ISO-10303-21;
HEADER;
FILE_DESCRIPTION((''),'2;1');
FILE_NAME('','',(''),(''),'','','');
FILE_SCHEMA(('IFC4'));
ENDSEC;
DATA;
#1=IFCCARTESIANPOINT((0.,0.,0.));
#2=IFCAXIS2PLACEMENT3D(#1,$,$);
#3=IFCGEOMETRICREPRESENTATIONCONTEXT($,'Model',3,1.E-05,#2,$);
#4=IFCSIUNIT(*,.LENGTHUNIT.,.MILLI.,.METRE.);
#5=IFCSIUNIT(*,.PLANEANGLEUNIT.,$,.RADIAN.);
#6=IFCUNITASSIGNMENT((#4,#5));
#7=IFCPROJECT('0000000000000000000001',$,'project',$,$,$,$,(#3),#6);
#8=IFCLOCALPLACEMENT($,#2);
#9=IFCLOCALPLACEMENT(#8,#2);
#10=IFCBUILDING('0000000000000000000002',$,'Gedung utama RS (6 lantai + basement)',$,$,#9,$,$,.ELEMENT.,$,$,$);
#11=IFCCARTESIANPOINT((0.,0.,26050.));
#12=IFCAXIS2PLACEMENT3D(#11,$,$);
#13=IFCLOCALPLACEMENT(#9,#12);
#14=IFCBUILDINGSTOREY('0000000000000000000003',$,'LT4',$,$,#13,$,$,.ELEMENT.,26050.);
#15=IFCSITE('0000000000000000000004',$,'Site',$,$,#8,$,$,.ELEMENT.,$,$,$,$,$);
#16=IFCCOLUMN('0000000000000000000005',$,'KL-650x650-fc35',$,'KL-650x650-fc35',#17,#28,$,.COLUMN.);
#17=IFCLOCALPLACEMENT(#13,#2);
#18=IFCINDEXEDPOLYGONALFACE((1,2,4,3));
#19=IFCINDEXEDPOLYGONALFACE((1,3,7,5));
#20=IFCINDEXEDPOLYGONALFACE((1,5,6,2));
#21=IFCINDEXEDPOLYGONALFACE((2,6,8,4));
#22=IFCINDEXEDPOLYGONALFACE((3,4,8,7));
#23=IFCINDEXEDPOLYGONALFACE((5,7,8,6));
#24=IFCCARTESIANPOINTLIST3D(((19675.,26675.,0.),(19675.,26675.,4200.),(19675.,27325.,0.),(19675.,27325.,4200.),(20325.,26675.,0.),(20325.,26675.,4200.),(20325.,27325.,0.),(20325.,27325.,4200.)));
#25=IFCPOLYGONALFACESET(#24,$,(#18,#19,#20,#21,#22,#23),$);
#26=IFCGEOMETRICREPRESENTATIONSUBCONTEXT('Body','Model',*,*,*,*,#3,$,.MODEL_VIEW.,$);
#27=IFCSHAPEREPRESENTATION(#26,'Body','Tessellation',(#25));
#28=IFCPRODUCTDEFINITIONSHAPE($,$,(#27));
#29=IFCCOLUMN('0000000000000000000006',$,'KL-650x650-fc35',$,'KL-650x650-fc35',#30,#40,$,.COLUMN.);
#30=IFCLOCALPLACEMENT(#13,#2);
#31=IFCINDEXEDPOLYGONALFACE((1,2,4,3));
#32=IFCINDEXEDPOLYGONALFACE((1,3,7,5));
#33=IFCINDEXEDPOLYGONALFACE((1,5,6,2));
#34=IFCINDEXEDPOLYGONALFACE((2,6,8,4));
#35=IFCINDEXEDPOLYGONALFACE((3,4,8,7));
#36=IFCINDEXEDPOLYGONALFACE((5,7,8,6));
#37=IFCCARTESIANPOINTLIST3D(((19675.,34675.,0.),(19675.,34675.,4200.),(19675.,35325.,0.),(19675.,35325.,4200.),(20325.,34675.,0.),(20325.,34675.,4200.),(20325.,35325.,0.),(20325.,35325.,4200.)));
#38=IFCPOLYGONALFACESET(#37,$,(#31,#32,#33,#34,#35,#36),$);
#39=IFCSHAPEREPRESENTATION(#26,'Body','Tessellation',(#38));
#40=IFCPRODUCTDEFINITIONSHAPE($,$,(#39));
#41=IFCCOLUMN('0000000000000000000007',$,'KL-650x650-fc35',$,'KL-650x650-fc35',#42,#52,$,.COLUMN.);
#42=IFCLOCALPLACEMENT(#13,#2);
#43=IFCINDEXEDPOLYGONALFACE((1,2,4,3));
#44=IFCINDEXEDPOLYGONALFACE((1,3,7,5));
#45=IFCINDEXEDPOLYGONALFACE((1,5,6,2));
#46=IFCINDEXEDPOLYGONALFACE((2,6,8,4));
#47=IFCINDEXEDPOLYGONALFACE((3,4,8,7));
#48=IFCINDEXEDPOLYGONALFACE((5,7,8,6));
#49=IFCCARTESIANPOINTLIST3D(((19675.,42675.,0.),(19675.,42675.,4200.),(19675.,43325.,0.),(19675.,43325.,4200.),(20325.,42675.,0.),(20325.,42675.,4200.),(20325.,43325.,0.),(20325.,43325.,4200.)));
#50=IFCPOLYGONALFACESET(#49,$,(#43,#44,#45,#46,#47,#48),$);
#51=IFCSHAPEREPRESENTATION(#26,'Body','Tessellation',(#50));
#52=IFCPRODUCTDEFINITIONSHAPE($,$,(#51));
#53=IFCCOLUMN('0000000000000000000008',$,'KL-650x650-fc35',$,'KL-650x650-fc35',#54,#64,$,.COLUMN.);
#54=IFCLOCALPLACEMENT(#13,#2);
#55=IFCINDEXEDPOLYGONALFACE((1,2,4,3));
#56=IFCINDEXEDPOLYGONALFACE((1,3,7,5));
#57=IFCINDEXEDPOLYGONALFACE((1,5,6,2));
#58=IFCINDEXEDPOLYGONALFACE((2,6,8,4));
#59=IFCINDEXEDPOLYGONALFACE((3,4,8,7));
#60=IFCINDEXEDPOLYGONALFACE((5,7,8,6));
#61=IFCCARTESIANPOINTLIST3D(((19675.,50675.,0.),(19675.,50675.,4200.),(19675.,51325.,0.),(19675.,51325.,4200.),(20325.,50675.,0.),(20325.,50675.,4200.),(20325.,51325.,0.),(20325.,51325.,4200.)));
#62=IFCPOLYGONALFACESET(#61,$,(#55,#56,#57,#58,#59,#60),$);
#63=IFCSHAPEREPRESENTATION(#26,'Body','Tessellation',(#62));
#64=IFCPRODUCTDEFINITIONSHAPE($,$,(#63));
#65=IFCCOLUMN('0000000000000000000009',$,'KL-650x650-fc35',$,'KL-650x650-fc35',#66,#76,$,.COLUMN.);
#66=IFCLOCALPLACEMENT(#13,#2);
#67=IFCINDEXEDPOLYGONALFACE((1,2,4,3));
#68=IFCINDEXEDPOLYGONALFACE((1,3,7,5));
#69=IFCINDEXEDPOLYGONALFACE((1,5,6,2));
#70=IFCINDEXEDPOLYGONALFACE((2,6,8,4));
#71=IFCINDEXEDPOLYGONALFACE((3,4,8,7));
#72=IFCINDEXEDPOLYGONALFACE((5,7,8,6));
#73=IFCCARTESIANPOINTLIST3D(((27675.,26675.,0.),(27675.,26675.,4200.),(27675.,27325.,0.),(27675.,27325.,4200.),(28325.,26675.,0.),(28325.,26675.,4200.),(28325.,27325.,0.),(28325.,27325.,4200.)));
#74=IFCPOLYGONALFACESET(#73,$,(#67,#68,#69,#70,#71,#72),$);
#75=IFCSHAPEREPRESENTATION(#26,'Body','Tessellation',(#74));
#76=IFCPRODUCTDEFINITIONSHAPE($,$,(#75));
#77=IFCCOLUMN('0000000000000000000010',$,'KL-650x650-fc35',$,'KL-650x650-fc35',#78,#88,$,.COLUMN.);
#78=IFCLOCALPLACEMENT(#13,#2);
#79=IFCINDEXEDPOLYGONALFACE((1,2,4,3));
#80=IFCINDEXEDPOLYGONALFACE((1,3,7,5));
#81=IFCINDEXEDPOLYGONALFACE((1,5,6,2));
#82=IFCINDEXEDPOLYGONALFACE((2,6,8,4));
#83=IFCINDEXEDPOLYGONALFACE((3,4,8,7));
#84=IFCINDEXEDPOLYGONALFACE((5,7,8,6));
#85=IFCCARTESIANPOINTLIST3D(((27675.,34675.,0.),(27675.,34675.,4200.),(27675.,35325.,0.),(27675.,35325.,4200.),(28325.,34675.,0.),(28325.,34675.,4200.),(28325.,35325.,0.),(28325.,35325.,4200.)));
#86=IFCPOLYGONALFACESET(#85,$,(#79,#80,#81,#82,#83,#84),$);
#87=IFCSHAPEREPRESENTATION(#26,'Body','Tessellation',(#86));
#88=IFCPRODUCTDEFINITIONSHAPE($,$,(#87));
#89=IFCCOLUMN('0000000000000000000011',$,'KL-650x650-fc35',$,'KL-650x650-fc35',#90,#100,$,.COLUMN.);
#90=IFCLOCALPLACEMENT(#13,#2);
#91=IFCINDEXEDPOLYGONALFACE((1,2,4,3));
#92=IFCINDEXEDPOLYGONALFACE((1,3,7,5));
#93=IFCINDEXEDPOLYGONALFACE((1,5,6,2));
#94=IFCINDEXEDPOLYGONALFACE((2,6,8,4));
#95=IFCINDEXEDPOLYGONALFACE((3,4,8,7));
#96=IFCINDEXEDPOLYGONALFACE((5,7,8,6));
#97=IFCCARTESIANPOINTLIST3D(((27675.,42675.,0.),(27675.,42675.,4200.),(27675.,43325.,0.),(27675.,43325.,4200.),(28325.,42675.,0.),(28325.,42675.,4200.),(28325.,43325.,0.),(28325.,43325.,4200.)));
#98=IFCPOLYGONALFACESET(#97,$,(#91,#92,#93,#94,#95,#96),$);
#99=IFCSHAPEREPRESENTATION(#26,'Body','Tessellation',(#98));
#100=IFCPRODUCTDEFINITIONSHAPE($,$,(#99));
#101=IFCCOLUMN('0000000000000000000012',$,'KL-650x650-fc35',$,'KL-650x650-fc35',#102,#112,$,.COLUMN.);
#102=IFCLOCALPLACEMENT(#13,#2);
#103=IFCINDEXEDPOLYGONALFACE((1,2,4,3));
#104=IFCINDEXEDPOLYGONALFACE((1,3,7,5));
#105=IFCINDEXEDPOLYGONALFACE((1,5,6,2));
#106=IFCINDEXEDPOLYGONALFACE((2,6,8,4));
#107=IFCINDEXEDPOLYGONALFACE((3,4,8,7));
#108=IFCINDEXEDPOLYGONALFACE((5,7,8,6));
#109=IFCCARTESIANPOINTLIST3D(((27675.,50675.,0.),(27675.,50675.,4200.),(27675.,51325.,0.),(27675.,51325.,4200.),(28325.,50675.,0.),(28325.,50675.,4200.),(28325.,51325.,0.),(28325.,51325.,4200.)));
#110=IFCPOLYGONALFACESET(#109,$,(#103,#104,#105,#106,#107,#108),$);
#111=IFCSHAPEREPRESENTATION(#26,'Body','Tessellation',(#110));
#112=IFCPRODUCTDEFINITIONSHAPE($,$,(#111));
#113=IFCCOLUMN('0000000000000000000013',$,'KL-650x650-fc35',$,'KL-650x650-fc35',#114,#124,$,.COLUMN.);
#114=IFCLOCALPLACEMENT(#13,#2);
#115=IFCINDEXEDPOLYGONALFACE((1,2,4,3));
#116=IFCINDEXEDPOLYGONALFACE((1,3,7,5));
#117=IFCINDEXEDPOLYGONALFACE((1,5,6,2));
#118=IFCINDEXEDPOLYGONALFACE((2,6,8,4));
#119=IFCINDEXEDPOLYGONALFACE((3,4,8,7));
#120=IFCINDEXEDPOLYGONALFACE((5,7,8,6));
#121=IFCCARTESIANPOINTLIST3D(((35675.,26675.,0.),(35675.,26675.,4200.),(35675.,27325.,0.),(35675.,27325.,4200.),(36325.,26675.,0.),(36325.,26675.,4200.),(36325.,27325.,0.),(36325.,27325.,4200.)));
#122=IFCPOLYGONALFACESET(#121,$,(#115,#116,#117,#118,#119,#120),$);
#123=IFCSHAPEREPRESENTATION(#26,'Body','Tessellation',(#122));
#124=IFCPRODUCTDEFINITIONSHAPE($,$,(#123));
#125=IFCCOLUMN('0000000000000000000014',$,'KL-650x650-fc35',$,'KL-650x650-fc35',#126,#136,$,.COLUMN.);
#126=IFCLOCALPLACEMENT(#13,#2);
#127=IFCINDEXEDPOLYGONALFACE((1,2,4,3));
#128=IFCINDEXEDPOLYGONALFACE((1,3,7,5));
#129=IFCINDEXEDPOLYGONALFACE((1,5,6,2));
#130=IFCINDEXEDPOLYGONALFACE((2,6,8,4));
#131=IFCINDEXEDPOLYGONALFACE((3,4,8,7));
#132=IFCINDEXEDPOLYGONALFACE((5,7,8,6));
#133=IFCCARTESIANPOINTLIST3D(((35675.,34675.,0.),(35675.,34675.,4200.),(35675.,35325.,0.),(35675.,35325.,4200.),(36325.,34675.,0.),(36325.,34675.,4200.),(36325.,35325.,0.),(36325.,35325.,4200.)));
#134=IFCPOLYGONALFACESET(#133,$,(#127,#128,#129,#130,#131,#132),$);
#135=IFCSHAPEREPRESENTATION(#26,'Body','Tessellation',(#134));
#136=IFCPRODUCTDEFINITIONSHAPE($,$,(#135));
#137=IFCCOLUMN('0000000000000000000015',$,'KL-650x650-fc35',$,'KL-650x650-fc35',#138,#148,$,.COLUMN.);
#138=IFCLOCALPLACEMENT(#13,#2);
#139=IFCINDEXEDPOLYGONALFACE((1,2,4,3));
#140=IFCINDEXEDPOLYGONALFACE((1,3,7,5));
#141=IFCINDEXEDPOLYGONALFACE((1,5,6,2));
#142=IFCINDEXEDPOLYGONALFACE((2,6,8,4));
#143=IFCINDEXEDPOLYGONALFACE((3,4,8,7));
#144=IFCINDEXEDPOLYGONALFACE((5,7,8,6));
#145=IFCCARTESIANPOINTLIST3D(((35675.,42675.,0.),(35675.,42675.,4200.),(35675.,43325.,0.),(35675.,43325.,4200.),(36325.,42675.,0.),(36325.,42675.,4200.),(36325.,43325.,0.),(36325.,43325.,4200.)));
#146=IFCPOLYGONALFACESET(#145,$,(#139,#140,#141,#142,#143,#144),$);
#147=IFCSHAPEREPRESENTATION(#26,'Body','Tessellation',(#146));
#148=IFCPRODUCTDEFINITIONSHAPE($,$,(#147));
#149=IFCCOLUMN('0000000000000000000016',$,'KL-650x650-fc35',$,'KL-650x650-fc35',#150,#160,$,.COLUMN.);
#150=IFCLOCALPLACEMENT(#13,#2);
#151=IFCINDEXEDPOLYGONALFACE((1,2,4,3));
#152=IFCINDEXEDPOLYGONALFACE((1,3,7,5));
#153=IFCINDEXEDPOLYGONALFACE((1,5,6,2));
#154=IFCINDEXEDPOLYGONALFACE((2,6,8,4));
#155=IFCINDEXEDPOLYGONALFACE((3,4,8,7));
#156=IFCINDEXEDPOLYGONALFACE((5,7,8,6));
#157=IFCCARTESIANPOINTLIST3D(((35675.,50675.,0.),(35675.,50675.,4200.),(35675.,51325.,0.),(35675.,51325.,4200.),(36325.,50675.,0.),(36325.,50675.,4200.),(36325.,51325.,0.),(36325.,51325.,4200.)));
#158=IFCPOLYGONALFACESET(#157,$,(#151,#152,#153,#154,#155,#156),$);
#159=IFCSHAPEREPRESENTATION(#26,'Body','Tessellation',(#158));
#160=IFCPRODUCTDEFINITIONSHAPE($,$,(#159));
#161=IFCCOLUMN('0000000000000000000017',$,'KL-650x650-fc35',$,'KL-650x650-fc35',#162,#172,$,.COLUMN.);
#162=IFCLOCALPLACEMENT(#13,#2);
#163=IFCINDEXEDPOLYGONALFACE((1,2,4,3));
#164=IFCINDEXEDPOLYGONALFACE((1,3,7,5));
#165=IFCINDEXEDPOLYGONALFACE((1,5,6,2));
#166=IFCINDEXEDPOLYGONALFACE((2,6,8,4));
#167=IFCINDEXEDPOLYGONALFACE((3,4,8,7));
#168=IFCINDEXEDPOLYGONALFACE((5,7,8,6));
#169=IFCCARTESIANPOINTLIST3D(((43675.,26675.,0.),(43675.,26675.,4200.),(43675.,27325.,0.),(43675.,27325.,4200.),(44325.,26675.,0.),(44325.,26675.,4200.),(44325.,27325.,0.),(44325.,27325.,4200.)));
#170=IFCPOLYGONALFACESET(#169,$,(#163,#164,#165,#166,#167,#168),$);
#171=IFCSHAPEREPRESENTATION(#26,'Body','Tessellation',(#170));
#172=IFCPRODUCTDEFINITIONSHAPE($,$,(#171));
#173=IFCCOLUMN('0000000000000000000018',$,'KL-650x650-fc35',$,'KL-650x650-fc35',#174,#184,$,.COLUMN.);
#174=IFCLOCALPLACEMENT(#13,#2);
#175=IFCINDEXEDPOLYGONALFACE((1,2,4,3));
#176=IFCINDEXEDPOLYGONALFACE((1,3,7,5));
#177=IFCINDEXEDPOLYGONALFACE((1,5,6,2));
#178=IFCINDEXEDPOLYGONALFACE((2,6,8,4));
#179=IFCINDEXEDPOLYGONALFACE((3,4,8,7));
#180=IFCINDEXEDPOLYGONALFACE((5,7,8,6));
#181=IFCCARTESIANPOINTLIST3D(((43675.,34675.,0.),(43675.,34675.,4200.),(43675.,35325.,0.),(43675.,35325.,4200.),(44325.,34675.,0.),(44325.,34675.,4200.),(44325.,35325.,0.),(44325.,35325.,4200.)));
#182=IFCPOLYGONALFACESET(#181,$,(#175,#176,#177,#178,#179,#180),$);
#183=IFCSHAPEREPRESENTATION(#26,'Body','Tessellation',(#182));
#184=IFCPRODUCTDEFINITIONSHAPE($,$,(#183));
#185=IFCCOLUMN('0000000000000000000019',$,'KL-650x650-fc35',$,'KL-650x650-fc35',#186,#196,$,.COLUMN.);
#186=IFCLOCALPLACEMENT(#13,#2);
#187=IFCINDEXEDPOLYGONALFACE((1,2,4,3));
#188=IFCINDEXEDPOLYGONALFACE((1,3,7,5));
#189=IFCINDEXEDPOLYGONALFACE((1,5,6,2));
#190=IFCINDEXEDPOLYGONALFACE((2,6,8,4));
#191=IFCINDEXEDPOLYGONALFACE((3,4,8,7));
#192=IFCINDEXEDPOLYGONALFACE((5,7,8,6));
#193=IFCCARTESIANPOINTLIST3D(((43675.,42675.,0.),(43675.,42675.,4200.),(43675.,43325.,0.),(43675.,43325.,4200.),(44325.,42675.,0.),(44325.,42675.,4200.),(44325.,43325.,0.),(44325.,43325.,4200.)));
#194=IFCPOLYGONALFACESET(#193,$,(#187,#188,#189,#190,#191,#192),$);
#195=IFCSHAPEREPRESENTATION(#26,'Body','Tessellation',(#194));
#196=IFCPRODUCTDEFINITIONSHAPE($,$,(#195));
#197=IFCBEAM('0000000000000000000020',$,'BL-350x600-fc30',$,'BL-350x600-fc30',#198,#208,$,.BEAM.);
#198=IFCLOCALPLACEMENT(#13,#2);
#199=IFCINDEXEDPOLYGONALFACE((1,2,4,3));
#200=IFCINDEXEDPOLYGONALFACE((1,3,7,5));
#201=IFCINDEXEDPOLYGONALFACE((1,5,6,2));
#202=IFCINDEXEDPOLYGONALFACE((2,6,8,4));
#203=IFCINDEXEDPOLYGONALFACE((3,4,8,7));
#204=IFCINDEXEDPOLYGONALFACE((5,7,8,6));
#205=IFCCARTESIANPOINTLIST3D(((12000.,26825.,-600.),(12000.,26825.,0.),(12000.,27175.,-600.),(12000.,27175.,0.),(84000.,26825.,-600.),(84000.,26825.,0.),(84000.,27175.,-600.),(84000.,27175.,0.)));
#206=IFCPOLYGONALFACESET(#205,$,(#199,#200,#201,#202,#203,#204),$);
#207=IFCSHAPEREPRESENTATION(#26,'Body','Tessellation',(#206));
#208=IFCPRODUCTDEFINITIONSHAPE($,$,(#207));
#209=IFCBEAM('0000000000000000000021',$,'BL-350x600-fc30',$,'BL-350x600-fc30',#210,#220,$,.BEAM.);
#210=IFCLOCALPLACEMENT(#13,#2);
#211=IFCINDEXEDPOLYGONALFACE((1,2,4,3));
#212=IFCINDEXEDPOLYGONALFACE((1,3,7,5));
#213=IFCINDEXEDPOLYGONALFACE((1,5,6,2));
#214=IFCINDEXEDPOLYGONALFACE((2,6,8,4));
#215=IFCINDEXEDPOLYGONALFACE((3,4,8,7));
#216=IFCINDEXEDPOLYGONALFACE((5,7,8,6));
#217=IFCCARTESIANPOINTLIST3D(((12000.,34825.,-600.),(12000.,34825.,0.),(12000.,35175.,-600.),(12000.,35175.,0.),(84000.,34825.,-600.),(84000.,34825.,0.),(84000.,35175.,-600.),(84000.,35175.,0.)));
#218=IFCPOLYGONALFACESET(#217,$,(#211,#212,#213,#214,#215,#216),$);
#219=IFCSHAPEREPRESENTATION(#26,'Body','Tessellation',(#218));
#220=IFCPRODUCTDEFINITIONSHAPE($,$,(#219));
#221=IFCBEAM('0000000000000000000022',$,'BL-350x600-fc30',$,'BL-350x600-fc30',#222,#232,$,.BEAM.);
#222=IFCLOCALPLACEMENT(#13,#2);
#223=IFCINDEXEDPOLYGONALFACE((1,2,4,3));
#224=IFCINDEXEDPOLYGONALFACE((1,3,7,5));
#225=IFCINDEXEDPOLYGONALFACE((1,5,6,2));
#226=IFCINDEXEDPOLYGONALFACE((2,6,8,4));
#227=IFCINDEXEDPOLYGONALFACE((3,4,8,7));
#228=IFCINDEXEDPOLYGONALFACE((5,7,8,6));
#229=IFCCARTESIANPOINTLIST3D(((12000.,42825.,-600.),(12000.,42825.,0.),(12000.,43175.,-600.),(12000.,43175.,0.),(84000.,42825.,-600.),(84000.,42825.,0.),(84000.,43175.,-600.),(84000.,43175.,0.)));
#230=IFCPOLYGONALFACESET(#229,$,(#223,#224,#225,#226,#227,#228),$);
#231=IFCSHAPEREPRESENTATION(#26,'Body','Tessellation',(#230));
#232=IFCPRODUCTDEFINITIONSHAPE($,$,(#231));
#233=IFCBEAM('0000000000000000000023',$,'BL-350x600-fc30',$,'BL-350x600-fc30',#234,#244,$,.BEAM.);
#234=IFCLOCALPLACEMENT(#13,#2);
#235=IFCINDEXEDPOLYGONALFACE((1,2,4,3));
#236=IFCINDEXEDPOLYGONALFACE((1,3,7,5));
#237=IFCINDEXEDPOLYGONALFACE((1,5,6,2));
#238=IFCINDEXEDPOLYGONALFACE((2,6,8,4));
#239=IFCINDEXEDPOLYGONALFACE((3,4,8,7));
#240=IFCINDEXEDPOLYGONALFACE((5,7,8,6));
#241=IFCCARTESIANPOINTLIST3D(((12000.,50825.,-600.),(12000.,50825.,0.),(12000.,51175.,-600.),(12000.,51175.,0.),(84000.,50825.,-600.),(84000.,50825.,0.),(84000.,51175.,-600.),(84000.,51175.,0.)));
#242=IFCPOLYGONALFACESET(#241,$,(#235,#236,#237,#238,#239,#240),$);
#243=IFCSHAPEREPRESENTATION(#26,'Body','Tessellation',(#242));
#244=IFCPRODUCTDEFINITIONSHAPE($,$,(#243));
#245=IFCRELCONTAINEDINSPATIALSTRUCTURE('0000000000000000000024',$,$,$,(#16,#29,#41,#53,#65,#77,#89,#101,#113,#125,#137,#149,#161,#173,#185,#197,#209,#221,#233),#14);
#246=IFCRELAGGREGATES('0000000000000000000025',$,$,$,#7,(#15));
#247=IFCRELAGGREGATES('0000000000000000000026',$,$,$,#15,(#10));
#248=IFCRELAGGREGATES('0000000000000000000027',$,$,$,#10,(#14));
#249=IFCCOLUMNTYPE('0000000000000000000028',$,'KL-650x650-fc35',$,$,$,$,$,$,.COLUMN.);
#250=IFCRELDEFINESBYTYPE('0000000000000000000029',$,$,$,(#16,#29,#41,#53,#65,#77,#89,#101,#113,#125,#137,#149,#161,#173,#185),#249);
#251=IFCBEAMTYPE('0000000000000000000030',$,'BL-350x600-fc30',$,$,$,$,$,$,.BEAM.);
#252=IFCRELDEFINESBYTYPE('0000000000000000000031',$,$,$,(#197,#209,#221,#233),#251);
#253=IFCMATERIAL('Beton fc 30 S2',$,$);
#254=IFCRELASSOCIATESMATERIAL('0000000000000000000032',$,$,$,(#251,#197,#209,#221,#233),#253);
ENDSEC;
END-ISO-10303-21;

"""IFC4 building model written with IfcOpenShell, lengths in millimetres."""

from ifc_helpers import new_model, si_unit, frame, origin, origin_2d, place, context, subcontext, project, spatial, rectangle, extrude, material, material_profile, profile_set, profile_usage, type_object, element, save


model = new_model("IFC4")

# Units and contexts
model_context = context("Model", 3, precision=1e-05, world=origin())
body_context = subcontext(model_context, "Body", "Model", "MODEL_VIEW")
ifc_project = project(units=[si_unit("LENGTHUNIT", "METRE", prefix="MILLI"), si_unit("PLANEANGLEUNIT", "RADIAN")], contexts=[model_context])

# Site, building, storey
site_placement = place(None, origin())
site = spatial("IfcSite", under=ifc_project, at=site_placement, Name="Site", CompositionType="ELEMENT")
building_placement = place(site_placement, origin())
building = spatial("IfcBuilding", under=site, at=building_placement, Name="Gedung utama RS (6 lantai + basement)", CompositionType="ELEMENT")
storey_placement = place(building_placement, frame((0.0, 0.0, 26050.0)))
storey = spatial("IfcBuildingStorey", under=building, at=storey_placement, Name="LT4", CompositionType="ELEMENT", Elevation=26050.0)

# Columns
ifc_material_profile_1 = material_profile(None, rectangle(XDim=650.0, YDim=650.0, at=origin_2d()), Name="KL-650x650-fc35")
ifc_profile_set_1 = profile_set([ifc_material_profile_1], Name="KL-650x650-fc35")
ifc_profile_usage_1 = profile_usage(ifc_profile_set_1, cardinal=5)
column_type = type_object("IfcColumnType", Name="KL-650x650-fc35", PredefinedType="COLUMN", material=ifc_profile_set_1)
for number, where, z_axis, x_axis, name in (
    (1, (20000.0, 27000.0, 0.0), (0.0, 0.0, 1.0), (1.0, 0.0, 0.0), "KL-650x650-fc35"),
    (2, (20000.0, 35000.0, 0.0), (0.0, 0.0, 1.0), (1.0, 0.0, 0.0), "KL-650x650-fc35"),
    (3, (20000.0, 43000.0, 0.0), (0.0, 0.0, 1.0), (1.0, 0.0, 0.0), "KL-650x650-fc35"),
    (4, (20000.0, 51000.0, 0.0), (0.0, 0.0, 1.0), (1.0, 0.0, 0.0), "KL-650x650-fc35"),
    (5, (28000.0, 27000.0, 0.0), (0.0, 0.0, 1.0), (1.0, 0.0, 0.0), "KL-650x650-fc35"),
    (6, (28000.0, 35000.0, 0.0), (0.0, 0.0, 1.0), (1.0, 0.0, 0.0), "KL-650x650-fc35"),
    (7, (28000.0, 43000.0, 0.0), (0.0, 0.0, 1.0), (1.0, 0.0, 0.0), "KL-650x650-fc35"),
    (8, (28000.0, 51000.0, 0.0), (0.0, 0.0, 1.0), (1.0, 0.0, 0.0), "KL-650x650-fc35"),
    (9, (36000.0, 27000.0, 0.0), (0.0, 0.0, 1.0), (1.0, 0.0, 0.0), "KL-650x650-fc35"),
    (10, (36000.0, 35000.0, 0.0), (0.0, 0.0, 1.0), (1.0, 0.0, 0.0), "KL-650x650-fc35"),
    (11, (36000.0, 43000.0, 0.0), (0.0, 0.0, 1.0), (1.0, 0.0, 0.0), "KL-650x650-fc35"),
    (12, (36000.0, 51000.0, 0.0), (0.0, 0.0, 1.0), (1.0, 0.0, 0.0), "KL-650x650-fc35"),
    (13, (44000.0, 27000.0, 0.0), (0.0, 0.0, 1.0), (1.0, 0.0, 0.0), "KL-650x650-fc35"),
    (14, (44000.0, 35000.0, 0.0), (0.0, 0.0, 1.0), (1.0, 0.0, 0.0), "KL-650x650-fc35"),
    (15, (44000.0, 43000.0, 0.0), (0.0, 0.0, 1.0), (1.0, 0.0, 0.0), "KL-650x650-fc35"),
):
    element("IfcColumn", number, at=place(storey_placement, frame(where, z_axis=z_axis, x_axis=x_axis)), inside=storey, type_object=column_type, material=ifc_profile_usage_1, Name=name, ObjectType="KL-650x650-fc35", PredefinedType="COLUMN", context=body_context, shape_type="SweptSolid", body=[
        extrude(rectangle(XDim=650.0, YDim=650.0, at=origin_2d()), origin(), (0.0, 0.0, 1.0), 4200.0),
    ])

# Beams
ifc_material = material(Name="Beton fc 30 S2")
ifc_material_profile_2 = material_profile(ifc_material, rectangle(XDim=350.0, YDim=600.0, at=origin_2d()), Name="BL-350x600-fc30")
ifc_profile_set_2 = profile_set([ifc_material_profile_2], Name="BL-350x600-fc30")
ifc_profile_usage_2 = profile_usage(ifc_profile_set_2, cardinal=8)
beam_type = type_object("IfcBeamType", Name="BL-350x600-fc30", PredefinedType="BEAM", material=ifc_profile_set_2)
for number, where, name in (
    (16, (12000.0, 27000.0, -300.0), "BL-350x600-fc30"),
    (17, (12000.0, 35000.0, -300.0), "BL-350x600-fc30"),
    (18, (12000.0, 43000.0, -300.0), "BL-350x600-fc30"),
    (19, (12000.0, 51000.0, -300.0), "BL-350x600-fc30"),
):
    element("IfcBeam", number, at=place(storey_placement, frame(where)), inside=storey, type_object=beam_type, material=ifc_profile_usage_2, Name=name, ObjectType="BL-350x600-fc30", PredefinedType="BEAM", context=body_context, shape_type="SweptSolid", body=[
        extrude(rectangle(XDim=350.0, YDim=600.0, at=origin_2d()), frame((0.0, 0.0, 0.0), z_axis=(1.0, 0.0, 0.0), x_axis=(0.0, 1.0, 0.0)), (0.0, 0.0, 1.0), 72000.0),
    ])

save(model, "model.ifc")
